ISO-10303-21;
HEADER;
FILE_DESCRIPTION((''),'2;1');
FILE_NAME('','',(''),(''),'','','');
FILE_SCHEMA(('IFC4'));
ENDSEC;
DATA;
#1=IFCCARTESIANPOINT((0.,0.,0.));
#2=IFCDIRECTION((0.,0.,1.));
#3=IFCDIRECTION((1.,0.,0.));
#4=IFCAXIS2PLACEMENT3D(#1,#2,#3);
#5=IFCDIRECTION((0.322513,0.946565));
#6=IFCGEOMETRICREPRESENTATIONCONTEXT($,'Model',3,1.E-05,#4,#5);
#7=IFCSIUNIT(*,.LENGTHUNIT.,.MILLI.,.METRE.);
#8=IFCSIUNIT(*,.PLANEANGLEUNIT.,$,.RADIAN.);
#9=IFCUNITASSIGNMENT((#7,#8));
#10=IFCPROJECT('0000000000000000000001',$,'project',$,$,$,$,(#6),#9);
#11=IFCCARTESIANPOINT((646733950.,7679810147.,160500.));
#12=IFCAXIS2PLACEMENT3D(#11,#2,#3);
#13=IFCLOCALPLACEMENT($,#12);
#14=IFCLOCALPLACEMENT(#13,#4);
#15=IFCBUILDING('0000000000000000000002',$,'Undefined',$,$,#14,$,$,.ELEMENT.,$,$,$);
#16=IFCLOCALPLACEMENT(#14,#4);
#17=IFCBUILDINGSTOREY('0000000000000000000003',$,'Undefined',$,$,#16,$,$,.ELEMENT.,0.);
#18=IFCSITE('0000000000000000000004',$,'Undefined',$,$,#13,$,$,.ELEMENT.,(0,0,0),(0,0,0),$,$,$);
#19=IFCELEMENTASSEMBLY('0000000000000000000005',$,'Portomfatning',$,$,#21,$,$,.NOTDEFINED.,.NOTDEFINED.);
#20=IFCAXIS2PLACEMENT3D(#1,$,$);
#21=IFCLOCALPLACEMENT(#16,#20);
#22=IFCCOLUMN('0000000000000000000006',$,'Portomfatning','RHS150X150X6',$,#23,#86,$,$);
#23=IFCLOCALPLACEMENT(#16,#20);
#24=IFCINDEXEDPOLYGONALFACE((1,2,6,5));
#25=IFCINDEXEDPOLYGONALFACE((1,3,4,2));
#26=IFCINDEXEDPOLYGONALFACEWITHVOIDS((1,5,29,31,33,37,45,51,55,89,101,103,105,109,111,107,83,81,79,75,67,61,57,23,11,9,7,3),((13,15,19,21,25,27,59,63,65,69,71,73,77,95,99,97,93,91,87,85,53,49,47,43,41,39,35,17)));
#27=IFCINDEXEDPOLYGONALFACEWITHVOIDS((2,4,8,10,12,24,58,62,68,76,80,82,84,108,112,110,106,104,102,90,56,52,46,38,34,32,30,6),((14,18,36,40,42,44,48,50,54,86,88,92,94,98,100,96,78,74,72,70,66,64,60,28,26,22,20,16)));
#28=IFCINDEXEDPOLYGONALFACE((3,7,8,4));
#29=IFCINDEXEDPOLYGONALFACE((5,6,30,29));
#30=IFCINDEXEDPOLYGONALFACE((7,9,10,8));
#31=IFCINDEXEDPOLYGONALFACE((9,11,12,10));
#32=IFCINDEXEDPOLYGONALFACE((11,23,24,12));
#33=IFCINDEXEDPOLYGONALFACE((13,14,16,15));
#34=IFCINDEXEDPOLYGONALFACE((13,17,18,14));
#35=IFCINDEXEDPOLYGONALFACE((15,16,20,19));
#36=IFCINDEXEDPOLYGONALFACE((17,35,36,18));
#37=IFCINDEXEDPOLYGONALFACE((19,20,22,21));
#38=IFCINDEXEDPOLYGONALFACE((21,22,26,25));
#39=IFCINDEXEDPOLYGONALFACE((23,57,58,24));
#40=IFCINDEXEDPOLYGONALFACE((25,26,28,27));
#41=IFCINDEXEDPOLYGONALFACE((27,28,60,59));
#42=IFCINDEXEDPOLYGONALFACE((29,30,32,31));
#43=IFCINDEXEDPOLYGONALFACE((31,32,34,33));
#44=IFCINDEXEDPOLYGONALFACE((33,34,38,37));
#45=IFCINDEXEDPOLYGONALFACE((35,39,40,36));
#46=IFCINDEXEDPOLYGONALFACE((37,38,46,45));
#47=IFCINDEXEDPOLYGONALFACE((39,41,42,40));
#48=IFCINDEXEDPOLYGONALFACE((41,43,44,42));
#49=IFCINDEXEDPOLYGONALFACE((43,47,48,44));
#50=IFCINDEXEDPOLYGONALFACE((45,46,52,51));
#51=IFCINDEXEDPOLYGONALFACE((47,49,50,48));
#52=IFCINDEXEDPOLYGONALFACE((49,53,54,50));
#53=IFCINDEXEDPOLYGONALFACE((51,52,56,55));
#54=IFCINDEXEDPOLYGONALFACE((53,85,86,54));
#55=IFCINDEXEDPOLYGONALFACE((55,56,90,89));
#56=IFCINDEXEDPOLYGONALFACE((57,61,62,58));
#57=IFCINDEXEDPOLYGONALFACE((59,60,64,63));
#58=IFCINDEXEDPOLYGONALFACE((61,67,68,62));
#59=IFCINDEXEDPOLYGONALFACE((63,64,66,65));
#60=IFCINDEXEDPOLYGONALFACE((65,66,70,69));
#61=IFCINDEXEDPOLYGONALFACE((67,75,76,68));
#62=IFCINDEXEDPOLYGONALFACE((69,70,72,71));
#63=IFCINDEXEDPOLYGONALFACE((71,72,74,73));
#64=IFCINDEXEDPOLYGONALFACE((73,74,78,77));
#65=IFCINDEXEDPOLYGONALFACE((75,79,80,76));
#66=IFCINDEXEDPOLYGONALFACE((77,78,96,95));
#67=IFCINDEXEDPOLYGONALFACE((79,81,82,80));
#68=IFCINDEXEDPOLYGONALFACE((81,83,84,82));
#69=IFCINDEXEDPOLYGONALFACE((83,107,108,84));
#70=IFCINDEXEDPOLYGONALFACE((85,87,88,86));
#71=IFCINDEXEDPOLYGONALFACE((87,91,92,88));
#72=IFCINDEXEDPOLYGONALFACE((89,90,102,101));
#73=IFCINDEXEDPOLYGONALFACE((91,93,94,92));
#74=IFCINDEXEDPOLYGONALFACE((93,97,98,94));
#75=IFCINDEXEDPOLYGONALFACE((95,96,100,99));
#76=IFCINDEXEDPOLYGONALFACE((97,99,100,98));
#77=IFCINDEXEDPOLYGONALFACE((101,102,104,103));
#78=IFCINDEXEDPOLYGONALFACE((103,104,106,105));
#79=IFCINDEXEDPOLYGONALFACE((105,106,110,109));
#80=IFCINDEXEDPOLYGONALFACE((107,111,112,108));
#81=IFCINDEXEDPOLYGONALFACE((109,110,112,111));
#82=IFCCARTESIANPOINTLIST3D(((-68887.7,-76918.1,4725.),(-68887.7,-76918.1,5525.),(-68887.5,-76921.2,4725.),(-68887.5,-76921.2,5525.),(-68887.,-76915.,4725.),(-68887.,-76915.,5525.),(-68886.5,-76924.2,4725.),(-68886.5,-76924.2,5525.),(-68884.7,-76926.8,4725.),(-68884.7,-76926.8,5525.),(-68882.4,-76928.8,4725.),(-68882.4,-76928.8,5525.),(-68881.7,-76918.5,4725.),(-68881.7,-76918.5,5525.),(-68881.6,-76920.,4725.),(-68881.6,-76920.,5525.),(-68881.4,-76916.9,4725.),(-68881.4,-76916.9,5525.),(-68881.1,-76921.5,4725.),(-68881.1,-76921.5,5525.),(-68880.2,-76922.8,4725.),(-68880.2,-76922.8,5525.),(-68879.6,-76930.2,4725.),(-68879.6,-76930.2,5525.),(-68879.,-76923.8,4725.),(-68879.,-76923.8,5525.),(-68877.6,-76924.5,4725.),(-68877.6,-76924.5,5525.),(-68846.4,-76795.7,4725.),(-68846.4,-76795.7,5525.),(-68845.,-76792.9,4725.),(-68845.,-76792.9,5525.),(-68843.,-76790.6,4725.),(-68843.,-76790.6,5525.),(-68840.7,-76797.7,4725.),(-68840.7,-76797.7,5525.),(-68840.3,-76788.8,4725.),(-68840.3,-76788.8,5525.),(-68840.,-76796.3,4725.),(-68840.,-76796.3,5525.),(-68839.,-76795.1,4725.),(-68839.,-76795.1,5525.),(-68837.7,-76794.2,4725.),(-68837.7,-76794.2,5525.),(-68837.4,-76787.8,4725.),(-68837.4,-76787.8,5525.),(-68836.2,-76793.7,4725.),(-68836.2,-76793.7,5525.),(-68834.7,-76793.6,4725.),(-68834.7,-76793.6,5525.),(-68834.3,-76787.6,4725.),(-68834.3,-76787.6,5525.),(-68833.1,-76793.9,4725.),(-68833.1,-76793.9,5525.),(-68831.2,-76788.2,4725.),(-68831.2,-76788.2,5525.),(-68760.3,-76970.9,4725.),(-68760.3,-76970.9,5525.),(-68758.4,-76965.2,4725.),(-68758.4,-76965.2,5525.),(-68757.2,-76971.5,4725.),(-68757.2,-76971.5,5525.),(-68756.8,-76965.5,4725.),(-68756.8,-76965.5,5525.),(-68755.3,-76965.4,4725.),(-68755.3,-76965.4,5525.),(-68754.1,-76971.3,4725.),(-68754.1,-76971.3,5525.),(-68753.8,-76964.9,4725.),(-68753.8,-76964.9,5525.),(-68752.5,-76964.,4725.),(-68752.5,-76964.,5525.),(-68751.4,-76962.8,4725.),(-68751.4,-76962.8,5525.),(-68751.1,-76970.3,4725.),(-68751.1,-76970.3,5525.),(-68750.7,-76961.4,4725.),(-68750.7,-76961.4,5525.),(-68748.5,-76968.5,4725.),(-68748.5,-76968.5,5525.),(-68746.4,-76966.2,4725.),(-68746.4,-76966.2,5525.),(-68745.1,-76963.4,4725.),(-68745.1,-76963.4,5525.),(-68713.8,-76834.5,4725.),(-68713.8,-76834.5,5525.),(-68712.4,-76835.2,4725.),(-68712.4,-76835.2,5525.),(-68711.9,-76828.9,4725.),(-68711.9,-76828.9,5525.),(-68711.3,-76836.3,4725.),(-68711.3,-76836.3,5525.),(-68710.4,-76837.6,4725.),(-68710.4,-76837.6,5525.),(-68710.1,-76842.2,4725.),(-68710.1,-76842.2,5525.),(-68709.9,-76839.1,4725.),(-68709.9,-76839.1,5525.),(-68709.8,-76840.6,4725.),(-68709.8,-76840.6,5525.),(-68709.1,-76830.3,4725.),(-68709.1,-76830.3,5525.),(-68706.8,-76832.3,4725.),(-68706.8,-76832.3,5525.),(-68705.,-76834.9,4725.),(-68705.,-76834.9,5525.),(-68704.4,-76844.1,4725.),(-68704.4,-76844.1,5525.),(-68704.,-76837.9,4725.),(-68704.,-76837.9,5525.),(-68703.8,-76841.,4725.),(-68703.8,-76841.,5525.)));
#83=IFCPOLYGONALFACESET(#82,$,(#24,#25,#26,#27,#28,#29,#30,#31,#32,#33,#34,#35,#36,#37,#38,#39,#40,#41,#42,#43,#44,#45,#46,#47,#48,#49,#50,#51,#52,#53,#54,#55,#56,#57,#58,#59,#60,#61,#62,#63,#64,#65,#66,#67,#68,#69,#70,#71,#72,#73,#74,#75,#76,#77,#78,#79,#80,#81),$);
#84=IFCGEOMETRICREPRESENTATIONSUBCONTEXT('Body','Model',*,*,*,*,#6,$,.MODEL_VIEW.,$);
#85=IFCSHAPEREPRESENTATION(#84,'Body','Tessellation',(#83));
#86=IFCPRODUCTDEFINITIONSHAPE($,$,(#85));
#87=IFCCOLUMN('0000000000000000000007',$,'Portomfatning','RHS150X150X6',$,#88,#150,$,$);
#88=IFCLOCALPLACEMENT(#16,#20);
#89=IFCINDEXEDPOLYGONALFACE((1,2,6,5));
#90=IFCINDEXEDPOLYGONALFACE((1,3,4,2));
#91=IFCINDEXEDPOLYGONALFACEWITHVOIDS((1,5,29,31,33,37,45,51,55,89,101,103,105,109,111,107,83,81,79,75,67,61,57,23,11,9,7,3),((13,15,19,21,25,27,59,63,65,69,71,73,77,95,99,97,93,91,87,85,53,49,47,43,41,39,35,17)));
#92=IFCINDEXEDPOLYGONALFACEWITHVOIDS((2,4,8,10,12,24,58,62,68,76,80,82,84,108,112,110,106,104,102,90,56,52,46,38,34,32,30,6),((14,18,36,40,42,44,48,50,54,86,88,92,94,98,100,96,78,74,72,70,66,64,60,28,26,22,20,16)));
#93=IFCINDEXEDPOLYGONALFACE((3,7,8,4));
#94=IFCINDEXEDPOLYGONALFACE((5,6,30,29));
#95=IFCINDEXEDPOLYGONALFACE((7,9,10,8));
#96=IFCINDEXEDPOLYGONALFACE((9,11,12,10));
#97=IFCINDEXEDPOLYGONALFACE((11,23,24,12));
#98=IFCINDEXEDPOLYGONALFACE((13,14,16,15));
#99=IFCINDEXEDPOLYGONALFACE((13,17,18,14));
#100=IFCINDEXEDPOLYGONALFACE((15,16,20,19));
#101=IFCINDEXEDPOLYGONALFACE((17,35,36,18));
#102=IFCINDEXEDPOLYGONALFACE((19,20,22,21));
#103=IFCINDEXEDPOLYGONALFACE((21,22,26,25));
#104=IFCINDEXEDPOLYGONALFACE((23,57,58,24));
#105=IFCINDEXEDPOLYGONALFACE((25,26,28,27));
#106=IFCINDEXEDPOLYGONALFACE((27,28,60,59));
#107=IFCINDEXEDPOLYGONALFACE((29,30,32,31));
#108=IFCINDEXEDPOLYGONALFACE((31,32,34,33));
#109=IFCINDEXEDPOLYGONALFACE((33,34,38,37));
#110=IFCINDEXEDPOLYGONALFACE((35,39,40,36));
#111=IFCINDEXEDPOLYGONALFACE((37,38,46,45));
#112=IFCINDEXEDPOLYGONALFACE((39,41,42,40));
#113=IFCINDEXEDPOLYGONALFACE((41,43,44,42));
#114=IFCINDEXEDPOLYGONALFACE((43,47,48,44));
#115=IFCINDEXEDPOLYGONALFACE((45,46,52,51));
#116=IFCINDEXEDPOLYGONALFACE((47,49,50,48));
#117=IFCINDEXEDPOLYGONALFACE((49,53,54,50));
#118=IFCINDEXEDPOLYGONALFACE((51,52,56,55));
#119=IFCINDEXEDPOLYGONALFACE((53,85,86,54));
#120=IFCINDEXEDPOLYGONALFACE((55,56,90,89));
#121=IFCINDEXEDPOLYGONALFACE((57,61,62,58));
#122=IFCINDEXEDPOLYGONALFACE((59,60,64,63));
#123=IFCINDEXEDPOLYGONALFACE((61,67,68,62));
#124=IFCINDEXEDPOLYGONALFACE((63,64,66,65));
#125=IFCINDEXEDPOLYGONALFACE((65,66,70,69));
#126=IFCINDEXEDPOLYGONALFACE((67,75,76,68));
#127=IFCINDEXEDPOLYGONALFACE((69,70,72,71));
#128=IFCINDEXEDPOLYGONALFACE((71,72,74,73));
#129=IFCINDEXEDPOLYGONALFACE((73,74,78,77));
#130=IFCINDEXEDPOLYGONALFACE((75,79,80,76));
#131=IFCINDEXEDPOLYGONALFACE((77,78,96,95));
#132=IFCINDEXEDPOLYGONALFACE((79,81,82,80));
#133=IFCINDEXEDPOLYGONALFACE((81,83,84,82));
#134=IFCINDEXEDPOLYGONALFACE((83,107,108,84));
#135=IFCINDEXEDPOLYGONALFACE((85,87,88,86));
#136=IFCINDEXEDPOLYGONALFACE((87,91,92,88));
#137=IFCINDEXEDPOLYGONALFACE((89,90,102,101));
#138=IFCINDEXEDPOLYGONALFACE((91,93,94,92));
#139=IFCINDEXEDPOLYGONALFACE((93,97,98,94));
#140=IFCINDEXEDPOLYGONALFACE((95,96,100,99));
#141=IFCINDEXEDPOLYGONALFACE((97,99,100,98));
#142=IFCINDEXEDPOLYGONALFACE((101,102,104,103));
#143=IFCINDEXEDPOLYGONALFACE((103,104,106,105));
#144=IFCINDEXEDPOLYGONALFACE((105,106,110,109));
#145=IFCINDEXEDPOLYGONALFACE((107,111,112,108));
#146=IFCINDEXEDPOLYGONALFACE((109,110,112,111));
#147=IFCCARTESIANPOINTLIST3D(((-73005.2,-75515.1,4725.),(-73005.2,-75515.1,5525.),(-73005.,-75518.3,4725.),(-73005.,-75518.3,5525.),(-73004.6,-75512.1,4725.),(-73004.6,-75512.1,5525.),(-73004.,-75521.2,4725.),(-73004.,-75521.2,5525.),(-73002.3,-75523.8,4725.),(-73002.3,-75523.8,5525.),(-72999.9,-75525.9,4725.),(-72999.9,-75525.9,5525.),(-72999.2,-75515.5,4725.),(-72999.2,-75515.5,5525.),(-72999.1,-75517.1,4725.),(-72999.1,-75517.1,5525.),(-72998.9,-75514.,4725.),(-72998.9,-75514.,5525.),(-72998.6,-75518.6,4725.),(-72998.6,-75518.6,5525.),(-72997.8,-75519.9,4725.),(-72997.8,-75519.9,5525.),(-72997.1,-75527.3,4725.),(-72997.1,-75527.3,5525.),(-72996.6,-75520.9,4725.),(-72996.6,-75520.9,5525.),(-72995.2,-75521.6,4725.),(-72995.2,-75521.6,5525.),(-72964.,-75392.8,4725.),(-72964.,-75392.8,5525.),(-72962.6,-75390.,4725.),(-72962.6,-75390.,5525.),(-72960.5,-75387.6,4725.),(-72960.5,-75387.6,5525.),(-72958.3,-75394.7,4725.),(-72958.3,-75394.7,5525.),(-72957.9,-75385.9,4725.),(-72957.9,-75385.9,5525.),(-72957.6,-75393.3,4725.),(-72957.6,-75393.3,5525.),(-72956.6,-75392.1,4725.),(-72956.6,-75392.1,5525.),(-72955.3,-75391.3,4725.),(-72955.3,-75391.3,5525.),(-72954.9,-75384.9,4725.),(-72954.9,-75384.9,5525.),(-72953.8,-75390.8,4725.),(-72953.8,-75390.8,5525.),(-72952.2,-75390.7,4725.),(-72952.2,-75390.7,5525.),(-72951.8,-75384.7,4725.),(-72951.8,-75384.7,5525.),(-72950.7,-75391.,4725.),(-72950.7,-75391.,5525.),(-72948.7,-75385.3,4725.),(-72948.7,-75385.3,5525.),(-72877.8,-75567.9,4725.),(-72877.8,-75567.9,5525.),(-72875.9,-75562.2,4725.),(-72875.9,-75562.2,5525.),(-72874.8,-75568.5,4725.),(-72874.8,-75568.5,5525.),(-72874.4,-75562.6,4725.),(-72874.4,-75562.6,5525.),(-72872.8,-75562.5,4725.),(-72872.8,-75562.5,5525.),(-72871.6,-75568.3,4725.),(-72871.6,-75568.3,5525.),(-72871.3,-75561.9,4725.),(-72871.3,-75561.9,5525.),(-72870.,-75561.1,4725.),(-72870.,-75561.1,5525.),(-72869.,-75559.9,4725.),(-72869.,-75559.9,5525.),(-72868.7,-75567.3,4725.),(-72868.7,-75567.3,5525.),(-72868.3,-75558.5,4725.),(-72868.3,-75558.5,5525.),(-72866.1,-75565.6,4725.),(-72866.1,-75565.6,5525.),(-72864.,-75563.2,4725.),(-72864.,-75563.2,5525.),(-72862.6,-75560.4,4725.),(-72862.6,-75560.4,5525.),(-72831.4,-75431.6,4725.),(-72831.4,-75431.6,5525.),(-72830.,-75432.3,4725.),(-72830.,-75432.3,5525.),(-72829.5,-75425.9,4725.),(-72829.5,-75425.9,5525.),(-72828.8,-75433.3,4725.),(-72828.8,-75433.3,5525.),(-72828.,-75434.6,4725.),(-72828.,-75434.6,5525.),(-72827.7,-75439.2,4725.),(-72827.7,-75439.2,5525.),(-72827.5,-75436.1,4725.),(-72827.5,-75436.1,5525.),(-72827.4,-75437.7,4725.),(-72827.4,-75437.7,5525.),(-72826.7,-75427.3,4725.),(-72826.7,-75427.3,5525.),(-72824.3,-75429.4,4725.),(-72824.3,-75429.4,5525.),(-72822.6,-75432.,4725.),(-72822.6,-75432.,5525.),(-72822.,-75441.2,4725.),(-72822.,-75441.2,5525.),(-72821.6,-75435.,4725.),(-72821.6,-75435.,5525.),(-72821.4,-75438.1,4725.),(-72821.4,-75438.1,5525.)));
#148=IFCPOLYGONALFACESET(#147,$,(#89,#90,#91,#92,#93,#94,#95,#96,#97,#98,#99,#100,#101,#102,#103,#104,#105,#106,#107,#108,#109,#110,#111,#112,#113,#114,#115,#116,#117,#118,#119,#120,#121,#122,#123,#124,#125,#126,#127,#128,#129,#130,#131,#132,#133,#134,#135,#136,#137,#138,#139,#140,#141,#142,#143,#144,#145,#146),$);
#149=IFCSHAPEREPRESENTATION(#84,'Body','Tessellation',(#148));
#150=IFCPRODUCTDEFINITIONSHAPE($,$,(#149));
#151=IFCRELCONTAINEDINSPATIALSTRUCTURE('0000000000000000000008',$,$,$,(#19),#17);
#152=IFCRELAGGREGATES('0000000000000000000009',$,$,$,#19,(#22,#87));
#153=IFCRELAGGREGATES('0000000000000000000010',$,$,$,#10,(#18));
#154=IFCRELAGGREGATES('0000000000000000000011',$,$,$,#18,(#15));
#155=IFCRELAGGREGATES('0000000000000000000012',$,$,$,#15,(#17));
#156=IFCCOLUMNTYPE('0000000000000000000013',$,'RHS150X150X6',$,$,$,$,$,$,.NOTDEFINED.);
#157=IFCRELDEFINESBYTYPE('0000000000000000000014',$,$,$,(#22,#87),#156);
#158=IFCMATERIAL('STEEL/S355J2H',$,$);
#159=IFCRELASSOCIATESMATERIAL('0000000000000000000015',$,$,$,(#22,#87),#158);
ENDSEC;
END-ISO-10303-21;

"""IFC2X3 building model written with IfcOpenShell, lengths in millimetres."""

from ifc_helpers import new_model, si_unit, direction, frame, origin_with_axes, origin_2d_with_axis, place, context, subcontext, project, spatial, hollow_rectangle, extrude, material, type_object, element, aggregate, save


model = new_model("IFC2X3")

# Units and contexts
model_context = context("Model", 3, precision=1e-05, world=origin_with_axes(), true_north=direction((0.322513, 0.946565)))
body_context = subcontext(model_context, "Body", "Model", "MODEL_VIEW")
ifc_project = project(units=[si_unit("LENGTHUNIT", "METRE", prefix="MILLI"), si_unit("PLANEANGLEUNIT", "RADIAN")], contexts=[model_context])

# Site, building, storey
site_placement = place(None, frame((646733950.0, 7679810147.0, 160500.0), z_axis=(0.0, 0.0, 1.0), x_axis=(1.0, 0.0, 0.0)))
site = spatial("IfcSite", under=ifc_project, at=site_placement, Name="Undefined", CompositionType="ELEMENT", RefLatitude=(0, 0, 0), RefLongitude=(0, 0, 0))
building_placement = place(site_placement, origin_with_axes())
building = spatial("IfcBuilding", under=site, at=building_placement, Name="Undefined", CompositionType="ELEMENT")
storey_placement = place(building_placement, origin_with_axes())
storey = spatial("IfcBuildingStorey", under=building, at=storey_placement, Name="Undefined", CompositionType="ELEMENT", Elevation=0.0)

# Element assembly, columns
assembly_1_placement = place(storey_placement, origin_with_axes())
assembly_1 = element("IfcElementAssembly", 1, at=assembly_1_placement, inside=storey, Name="Portomfatning", AssemblyPlace="NOTDEFINED", PredefinedType="NOTDEFINED")
ifc_material_1 = material(Name="STEEL/S355J2H")
column_type_1 = type_object("IfcColumnType", Name="RHS150X150X6", PredefinedType="NOTDEFINED")
column_1_placement = place(assembly_1_placement, frame((-68795.7, -76879.5, 4725.0), z_axis=(0.0, 0.0, 1.0), x_axis=(0.946565, -0.322513, 0.0)))
column_1 = element("IfcColumn", 2, at=column_1_placement, type_object=column_type_1, material=ifc_material_1, Name="Portomfatning", Description="RHS150X150X6", context=body_context, shape_type="SweptSolid", body=[
    extrude(hollow_rectangle(XDim=150.0, YDim=150.0, WallThickness=6.0, InnerFilletRadius=6.0, OuterFilletRadius=12.0, at=origin_2d_with_axis()), frame((0.0, 0.0, 800.0), z_axis=(0.0, 0.0, -1.0), x_axis=(0.0, 1.0, 0.0)), (0.0, 0.0, 1.0), 800.0),
])
column_2_placement = place(assembly_1_placement, frame((-72913.3, -75476.6, 4725.0), z_axis=(0.0, 0.0, 1.0), x_axis=(-0.946565, 0.322513, 0.0)))
column_2 = element("IfcColumn", 3, at=column_2_placement, type_object=column_type_1, material=ifc_material_1, Name="Portomfatning", Description="RHS150X150X6", context=body_context, shape_type="SweptSolid", body=[
    extrude(hollow_rectangle(XDim=150.0, YDim=150.0, WallThickness=6.0, InnerFilletRadius=6.0, OuterFilletRadius=12.0, at=origin_2d_with_axis()), frame((0.0, 0.0, 800.0), z_axis=(0.0, 0.0, -1.0), x_axis=(0.0, 1.0, 0.0)), (0.0, 0.0, 1.0), 800.0),
])

aggregate(assembly_1, [column_1, column_2])

save(model, "model.ifc")
